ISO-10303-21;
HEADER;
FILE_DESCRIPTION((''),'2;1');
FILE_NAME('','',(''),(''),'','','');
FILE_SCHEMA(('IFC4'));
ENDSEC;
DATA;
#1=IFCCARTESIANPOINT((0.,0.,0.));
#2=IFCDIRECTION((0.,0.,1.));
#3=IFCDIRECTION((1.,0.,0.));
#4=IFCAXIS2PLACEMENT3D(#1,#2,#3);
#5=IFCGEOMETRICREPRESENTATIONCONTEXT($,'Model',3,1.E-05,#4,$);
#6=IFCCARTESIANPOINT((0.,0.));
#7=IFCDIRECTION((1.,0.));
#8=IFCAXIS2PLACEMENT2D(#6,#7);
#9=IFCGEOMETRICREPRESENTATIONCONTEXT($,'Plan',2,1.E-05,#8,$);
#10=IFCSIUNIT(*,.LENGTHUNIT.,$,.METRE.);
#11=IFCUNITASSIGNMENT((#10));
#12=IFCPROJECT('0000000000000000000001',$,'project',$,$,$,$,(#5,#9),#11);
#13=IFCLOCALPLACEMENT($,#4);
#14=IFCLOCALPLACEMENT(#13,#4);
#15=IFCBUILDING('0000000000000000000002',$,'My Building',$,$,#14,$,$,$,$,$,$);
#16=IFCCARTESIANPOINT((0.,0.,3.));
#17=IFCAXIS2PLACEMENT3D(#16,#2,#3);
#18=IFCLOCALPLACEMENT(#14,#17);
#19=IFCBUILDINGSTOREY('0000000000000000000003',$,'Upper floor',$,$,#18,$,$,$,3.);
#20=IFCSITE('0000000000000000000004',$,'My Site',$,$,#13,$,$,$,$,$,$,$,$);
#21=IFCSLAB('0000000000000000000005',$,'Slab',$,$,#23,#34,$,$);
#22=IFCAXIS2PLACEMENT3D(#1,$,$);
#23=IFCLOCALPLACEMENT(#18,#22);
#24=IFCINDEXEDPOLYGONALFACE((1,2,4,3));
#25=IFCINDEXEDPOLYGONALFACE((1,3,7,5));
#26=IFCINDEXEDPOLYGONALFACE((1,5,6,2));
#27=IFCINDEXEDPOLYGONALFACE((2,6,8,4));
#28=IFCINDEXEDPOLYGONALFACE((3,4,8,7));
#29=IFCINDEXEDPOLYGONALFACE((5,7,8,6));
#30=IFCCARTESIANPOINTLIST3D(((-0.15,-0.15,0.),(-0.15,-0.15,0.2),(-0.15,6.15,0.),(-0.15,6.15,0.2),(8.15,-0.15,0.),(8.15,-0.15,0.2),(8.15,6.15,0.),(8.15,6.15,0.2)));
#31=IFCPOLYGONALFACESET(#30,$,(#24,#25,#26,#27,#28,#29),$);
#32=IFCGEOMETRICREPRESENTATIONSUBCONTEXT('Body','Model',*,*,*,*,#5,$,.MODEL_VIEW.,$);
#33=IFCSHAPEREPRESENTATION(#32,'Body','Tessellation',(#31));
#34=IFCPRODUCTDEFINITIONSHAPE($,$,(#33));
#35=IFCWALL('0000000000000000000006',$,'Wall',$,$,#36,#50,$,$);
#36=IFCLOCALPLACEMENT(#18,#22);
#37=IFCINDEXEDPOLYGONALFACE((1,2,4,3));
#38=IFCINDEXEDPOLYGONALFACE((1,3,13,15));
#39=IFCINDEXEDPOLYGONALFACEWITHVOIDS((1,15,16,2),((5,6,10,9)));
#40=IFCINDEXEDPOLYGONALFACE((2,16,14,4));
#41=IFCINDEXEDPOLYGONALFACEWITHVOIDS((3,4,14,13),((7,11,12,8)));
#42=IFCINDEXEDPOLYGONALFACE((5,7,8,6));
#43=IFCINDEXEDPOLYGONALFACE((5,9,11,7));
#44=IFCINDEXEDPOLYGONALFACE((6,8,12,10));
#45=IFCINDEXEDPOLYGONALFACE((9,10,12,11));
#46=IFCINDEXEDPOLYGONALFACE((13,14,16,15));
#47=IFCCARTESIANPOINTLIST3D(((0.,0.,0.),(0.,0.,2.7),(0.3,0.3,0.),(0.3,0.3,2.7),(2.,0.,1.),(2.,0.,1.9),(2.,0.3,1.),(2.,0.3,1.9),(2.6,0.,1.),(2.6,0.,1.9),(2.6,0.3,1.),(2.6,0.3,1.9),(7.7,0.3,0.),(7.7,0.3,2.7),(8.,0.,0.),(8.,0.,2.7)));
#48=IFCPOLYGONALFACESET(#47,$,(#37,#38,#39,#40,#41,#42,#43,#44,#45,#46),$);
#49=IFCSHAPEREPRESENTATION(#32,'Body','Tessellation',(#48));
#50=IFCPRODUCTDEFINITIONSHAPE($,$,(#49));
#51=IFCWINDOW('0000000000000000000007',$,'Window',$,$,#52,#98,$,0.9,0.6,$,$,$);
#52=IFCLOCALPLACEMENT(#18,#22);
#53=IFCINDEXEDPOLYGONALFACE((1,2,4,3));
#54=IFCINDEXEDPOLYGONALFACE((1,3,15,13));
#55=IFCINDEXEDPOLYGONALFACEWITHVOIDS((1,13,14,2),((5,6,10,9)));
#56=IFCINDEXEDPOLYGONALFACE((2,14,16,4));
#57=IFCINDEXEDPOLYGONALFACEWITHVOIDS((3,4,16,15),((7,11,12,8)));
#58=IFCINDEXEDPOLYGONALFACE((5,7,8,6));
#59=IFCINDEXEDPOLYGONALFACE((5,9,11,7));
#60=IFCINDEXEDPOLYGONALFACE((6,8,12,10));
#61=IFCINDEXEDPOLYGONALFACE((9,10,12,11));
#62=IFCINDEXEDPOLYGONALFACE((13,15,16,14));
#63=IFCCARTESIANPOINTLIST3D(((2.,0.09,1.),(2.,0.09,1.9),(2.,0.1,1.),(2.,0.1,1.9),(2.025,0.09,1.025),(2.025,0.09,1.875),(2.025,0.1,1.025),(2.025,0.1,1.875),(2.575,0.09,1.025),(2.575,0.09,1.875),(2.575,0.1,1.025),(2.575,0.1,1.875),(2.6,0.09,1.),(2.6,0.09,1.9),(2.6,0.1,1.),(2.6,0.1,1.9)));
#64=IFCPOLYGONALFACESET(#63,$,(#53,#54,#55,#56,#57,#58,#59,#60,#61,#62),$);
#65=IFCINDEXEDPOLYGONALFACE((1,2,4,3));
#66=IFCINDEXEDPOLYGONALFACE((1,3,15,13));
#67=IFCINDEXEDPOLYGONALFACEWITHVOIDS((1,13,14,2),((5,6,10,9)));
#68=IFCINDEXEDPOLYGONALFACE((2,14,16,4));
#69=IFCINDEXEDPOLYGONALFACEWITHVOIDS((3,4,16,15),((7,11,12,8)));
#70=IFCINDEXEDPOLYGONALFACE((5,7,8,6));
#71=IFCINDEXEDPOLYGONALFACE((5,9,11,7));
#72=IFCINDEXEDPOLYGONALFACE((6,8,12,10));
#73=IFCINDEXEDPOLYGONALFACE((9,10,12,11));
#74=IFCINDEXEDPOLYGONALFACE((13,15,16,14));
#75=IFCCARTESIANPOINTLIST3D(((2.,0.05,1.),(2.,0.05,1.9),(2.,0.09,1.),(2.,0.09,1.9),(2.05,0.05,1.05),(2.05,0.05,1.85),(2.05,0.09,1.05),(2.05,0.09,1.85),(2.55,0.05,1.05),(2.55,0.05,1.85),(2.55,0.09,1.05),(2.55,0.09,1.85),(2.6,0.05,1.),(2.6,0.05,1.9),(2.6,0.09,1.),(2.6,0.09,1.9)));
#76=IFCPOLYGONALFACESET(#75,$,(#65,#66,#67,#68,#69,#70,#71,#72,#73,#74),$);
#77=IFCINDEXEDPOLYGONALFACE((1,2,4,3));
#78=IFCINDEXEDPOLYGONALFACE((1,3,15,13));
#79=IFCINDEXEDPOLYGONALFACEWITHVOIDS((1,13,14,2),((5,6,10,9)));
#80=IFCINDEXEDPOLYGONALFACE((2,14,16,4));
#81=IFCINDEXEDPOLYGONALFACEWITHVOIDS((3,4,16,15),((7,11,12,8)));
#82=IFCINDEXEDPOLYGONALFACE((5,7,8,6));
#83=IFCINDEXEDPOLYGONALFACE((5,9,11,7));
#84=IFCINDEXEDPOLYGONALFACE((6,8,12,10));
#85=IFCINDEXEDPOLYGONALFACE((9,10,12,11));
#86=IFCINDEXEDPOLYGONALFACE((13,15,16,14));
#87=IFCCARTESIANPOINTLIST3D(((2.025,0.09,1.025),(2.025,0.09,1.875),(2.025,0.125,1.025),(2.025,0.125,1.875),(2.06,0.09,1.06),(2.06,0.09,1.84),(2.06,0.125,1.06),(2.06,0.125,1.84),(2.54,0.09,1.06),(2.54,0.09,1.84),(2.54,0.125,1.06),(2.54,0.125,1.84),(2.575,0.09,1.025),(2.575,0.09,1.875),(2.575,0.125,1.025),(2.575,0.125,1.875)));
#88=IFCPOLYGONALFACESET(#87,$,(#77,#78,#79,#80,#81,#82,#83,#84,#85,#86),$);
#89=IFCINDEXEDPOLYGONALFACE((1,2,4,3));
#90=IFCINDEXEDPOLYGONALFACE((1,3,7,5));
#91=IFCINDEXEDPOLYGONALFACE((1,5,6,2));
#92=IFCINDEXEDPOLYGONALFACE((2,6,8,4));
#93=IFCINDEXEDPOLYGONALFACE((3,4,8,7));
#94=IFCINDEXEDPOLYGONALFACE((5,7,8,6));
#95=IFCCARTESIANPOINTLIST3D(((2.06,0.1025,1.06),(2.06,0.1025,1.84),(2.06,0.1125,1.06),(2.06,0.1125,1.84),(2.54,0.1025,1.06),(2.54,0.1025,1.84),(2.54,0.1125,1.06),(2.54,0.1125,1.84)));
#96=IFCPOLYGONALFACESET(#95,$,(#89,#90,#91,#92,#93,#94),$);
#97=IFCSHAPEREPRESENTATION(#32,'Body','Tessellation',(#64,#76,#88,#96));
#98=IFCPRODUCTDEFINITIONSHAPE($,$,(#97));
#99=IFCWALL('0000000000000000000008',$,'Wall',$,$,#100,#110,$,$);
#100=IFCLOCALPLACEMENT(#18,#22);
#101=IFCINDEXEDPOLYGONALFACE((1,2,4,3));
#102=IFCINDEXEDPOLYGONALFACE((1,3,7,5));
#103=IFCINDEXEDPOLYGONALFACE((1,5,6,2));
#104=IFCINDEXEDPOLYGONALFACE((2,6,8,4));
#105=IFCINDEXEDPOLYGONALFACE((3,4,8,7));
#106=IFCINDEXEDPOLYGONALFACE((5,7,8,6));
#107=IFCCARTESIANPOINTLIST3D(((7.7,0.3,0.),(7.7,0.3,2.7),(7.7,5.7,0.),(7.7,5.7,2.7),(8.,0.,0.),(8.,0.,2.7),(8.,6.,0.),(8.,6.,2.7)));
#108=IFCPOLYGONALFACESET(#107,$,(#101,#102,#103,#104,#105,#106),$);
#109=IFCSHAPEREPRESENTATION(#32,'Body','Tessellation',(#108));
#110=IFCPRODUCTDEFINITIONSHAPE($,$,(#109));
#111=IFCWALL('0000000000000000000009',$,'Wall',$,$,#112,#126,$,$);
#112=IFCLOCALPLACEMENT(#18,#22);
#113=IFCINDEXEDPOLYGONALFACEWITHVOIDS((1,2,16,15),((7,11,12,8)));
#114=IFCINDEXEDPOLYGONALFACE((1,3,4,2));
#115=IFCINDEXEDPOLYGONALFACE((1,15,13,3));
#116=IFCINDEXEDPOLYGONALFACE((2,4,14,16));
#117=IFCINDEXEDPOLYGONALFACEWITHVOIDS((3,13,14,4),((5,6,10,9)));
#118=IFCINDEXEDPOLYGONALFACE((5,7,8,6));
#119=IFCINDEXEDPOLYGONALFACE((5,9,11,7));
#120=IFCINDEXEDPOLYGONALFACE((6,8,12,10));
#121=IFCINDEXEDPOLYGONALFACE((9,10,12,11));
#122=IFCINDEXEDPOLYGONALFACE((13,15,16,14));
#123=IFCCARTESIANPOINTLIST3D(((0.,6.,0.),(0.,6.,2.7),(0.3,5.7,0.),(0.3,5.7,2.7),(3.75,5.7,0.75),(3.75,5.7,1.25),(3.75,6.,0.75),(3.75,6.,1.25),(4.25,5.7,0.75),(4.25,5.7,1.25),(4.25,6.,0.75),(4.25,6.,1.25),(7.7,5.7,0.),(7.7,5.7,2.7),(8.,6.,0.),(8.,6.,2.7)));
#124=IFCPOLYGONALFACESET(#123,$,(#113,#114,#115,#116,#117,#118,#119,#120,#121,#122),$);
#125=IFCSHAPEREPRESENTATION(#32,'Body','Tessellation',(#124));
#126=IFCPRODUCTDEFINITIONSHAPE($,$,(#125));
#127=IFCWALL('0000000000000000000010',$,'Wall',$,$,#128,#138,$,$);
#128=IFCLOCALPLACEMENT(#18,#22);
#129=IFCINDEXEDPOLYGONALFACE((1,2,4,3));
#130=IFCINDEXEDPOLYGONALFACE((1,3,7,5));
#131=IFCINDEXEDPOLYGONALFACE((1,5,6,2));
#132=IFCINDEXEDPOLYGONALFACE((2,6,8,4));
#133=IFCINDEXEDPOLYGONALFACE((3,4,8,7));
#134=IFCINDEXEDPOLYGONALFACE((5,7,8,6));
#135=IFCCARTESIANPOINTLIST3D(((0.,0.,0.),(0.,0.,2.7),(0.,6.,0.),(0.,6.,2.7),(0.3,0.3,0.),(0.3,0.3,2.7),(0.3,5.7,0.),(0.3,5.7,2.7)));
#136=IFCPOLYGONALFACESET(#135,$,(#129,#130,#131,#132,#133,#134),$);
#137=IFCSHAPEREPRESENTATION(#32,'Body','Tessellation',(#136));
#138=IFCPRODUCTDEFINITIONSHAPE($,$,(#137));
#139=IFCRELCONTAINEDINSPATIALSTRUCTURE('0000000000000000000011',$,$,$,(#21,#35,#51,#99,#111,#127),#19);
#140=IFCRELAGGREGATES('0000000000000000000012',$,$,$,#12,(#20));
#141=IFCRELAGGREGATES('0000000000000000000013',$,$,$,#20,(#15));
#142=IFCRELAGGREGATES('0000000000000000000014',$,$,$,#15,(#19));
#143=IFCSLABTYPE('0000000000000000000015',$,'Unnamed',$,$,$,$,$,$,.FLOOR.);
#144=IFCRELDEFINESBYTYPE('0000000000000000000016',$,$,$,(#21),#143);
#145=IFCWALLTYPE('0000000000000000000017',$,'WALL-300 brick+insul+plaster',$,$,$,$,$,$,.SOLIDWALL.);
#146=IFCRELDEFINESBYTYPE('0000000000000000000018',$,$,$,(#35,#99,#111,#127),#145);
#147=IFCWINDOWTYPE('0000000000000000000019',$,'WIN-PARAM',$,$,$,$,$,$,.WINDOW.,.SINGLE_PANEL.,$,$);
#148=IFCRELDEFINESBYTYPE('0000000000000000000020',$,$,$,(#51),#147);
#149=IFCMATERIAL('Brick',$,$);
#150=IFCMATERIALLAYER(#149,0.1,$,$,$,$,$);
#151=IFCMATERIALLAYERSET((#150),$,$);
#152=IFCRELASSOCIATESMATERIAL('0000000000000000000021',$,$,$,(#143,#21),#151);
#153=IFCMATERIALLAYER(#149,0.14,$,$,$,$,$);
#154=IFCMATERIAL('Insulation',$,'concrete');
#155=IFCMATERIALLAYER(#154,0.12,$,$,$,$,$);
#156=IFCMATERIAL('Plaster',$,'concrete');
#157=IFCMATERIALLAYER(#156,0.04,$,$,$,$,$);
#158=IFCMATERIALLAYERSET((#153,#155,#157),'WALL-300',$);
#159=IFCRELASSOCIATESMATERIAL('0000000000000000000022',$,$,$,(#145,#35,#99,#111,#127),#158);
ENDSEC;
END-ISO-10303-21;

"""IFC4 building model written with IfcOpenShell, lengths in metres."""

from ifc_helpers import new_model, entity, si_unit, frame, origin_with_axes, origin_2d_with_axis, place, context, subcontext, project, spatial, line, indexed_curve, outline, extrude, shape, source, transform, mapped, material, layer, layer_set, layer_usage, type_object, type_shapes, element, fill, save


model = new_model("IFC4")

# Units and contexts
model_context = context("Model", 3, precision=1e-05, world=origin_with_axes())
plan_context = context("Plan", 2, precision=1e-05, world=origin_2d_with_axis())
body_context_1 = subcontext(model_context, "Body", "Model", "MODEL_VIEW")
body_context_2 = subcontext(plan_context, "Body", "Plan", "PLAN_VIEW")
ifc_project = project(units=[si_unit("LENGTHUNIT", "METRE")], contexts=[model_context, plan_context])

# Site, building, storey
site_placement = place(None, origin_with_axes())
site = spatial("IfcSite", under=ifc_project, at=site_placement, Name="My Site")
building_placement = place(site_placement, origin_with_axes())
building = spatial("IfcBuilding", under=site, at=building_placement, Name="My Building")
storey_placement = place(building_placement, frame((0.0, 0.0, 3.0), z_axis=(0.0, 0.0, 1.0), x_axis=(1.0, 0.0, 0.0)))
storey = spatial("IfcBuildingStorey", under=building, at=storey_placement, Name="Upper floor", Elevation=3.0)

# Slab
ifc_material_1 = material(Name="Brick")
ifc_layer_1 = layer(ifc_material_1, 0.1)
ifc_layer_set_1 = layer_set([ifc_layer_1])
ifc_layer_usage_1 = layer_usage(ifc_layer_set_1, "AXIS3", "POSITIVE", 0.0)
slab_type = type_object("IfcSlabType", Name="Unnamed", PredefinedType="FLOOR", material=ifc_layer_set_1)
slab_placement = place(storey_placement, origin_with_axes())
element("IfcSlab", 1, at=slab_placement, inside=storey, type_object=slab_type, material=ifc_layer_usage_1, Name="Slab", context=body_context_1, shape_type="SweptSolid", body=[
    extrude(outline(indexed_curve([(-0.15, -0.15), (8.15, -0.15), (8.15, 6.15), (-0.15, 6.15), (-0.15, -0.15)])), None, (0.0, 0.0, 1.0), 0.2),
])

# Wall, opening, window
ifc_layer_2 = layer(ifc_material_1, 0.14)
ifc_material_2 = material(Name="Insulation", Category="concrete")
ifc_layer_3 = layer(ifc_material_2, 0.12)
ifc_material_3 = material(Name="Plaster", Category="concrete")
ifc_layer_4 = layer(ifc_material_3, 0.04)
ifc_layer_set_2 = layer_set([ifc_layer_2, ifc_layer_3, ifc_layer_4], Name="WALL-300")
ifc_layer_usage_2 = layer_usage(ifc_layer_set_2, "AXIS2", "POSITIVE", 0.0)
wall_type = type_object("IfcWallType", Name="WALL-300 brick+insul+plaster", PredefinedType="SOLIDWALL", material=ifc_layer_set_2)
wall_1_placement = place(storey_placement, frame((0.0, 0.0, 0.0), z_axis=(0.0, 0.0, 1.0), x_axis=(1.0, 0.0, 0.0)))
wall_1 = element("IfcWall", 2, at=wall_1_placement, inside=storey, type_object=wall_type, material=ifc_layer_usage_2, Name="Wall", context=body_context_1, shape_type="SweptSolid", body=[
    extrude(outline(indexed_curve([(0.0, 0.0), (0.3, 0.3), (7.7, 0.3), (8.0, 0.0)], segments=[line(1, 2, 3, 4, 1)])), origin_with_axes(), (0.0, 0.0, 1.0), 2.7),
])
shared_shape_1 = source(origin_with_axes(), body_context_1, "Body", "SweptSolid", [
    extrude(outline(indexed_curve([(0.0, 0.0), (0.6, 0.0), (0.6, 0.9), (0.0, 0.9)], segments=[line(1, 2, 3, 4, 1)])), frame((0.0, -0.6, 0.0), z_axis=(0.0, -1.0, 0.0), x_axis=(1.0, 0.0, 0.0)), (0.0, 0.0, -1.0), 1.2),
])
opening_1_placement = place(wall_1_placement, frame((2.0, 0.0, 1.0), z_axis=(0.0, 0.0, 1.0), x_axis=(1.0, 0.0, 0.0)))
opening_1 = element("IfcOpeningElement", 3, at=opening_1_placement, cuts=wall_1, PredefinedType="OPENING", context=body_context_1, shape_type="MappedRepresentation", body=[
    mapped(shared_shape_1, transform((0.0, 0.0, 0.0), x_axis=(1.0, 0.0, 0.0), y_axis=(0.0, 1.0, 0.0), z_axis=(0.0, 0.0, 1.0), scale=1.0)),
])
window_type = type_object("IfcWindowType", Name="WIN-PARAM", PartitioningType="SINGLE_PANEL", PredefinedType="WINDOW")
shared_shape_2 = source(origin_with_axes(), body_context_1, "Body", "SweptSolid", [
    extrude(outline(indexed_curve([(0.0, 0.0), (0.6, 0.0), (0.6, 0.9), (0.0, 0.9)], segments=[line(1, 2, 3, 4, 1)]), holes=[indexed_curve([(0.025, 0.025), (0.575, 0.025), (0.575, 0.875), (0.025, 0.875)], segments=[line(1, 2, 3, 4, 1)])]), frame((0.0, 0.09, 0.0), z_axis=(0.0, -1.0, 0.0), x_axis=(1.0, 0.0, 0.0)), (0.0, 0.0, -1.0), 0.01),
    extrude(outline(indexed_curve([(0.0, 0.0), (0.6, 0.0), (0.6, 0.9), (0.0, 0.9)], segments=[line(1, 2, 3, 4, 1)]), holes=[indexed_curve([(0.05, 0.05), (0.55, 0.05), (0.55, 0.85), (0.05, 0.85)], segments=[line(1, 2, 3, 4, 1)])]), frame((0.0, 0.05, 0.0), z_axis=(0.0, -1.0, 0.0), x_axis=(1.0, 0.0, 0.0)), (0.0, 0.0, -1.0), 0.04),
    extrude(outline(indexed_curve([(0.0, 0.0), (0.55, 0.0), (0.55, 0.85), (0.0, 0.85)], segments=[line(1, 2, 3, 4, 1)]), holes=[indexed_curve([(0.035, 0.035), (0.515, 0.035), (0.515, 0.815), (0.035, 0.815)], segments=[line(1, 2, 3, 4, 1)])]), frame((0.025, 0.09, 0.025), z_axis=(0.0, -1.0, 0.0), x_axis=(1.0, 0.0, 0.0)), (0.0, 0.0, -1.0), 0.035),
    extrude(outline(indexed_curve([(0.035, 0.035), (0.515, 0.035), (0.515, 0.815), (0.035, 0.815)], segments=[line(1, 2, 3, 4, 1)])), frame((0.025, 0.1025, 0.025), z_axis=(0.0, -1.0, 0.0), x_axis=(1.0, 0.0, 0.0)), (0.0, 0.0, -1.0), 0.01),
])
shared_shape_3 = source(origin_with_axes(), body_context_2, "Body", "Curve2D", [
    entity("IfcIndexedPolyCurve", entity("IfcCartesianPointList2D", [[0.05, 0.05], [0.55, 0.05]])),
    entity("IfcIndexedPolyCurve", entity("IfcCartesianPointList2D", [[0.0, 0.1], [0.025, 0.1], [0.025, 0.09], [0.05, 0.09], [0.05, 0.05], [0.0, 0.05]]), [entity("IfcLineIndex", [1, 2, 3, 4, 5, 6, 1])]),
    entity("IfcIndexedPolyCurve", entity("IfcCartesianPointList2D", [[0.6, 0.1], [0.575, 0.1], [0.575, 0.09], [0.55, 0.09], [0.55, 0.05], [0.6, 0.05]]), [entity("IfcLineIndex", [1, 2, 3, 4, 5, 6, 1])]),
    entity("IfcIndexedPolyCurve", entity("IfcCartesianPointList2D", [[0.025, 0.09], [0.06, 0.09], [0.06, 0.125], [0.025, 0.125]]), [entity("IfcLineIndex", [1, 2, 3, 4, 1])]),
    entity("IfcIndexedPolyCurve", entity("IfcCartesianPointList2D", [[0.575, 0.09], [0.54, 0.09], [0.54, 0.125], [0.575, 0.125]]), [entity("IfcLineIndex", [1, 2, 3, 4, 1])]),
    entity("IfcIndexedPolyCurve", entity("IfcCartesianPointList2D", [[0.06, 0.09], [0.54, 0.09]])),
    entity("IfcIndexedPolyCurve", entity("IfcCartesianPointList2D", [[0.06, 0.125], [0.54, 0.125]])),
    entity("IfcIndexedPolyCurve", entity("IfcCartesianPointList2D", [[0.06, 0.1075], [0.54, 0.1075]])),
])
type_shapes(window_type, [shared_shape_2, shared_shape_3])
window_placement = place(opening_1_placement, origin_with_axes())
window = element("IfcWindow", 4, at=window_placement, inside=storey, type_object=window_type, Name="Window", OverallHeight=0.9, OverallWidth=0.6, shapes=[
    shape(body_context_1, "Body", "MappedRepresentation", [mapped(shared_shape_2, transform((0.0, 0.0, 0.0), x_axis=(1.0, 0.0, 0.0), y_axis=(0.0, 1.0, 0.0), z_axis=(0.0, 0.0, 1.0), scale=1.0))]),
    shape(body_context_2, "Body", "MappedRepresentation", [mapped(shared_shape_3, transform((0.0, 0.0, 0.0), x_axis=(1.0, 0.0, 0.0), y_axis=(0.0, 1.0, 0.0), z_axis=(0.0, 0.0, 1.0), scale=1.0))]),
])
fill(opening_1, window)

# Wall
ifc_layer_usage_3 = layer_usage(ifc_layer_set_2, "AXIS2", "POSITIVE", 0.0)
wall_2_placement = place(storey_placement, frame((8.0, 0.0, 0.0), z_axis=(0.0, 0.0, 1.0), x_axis=(0.0, 1.0, 0.0)))
element("IfcWall", 5, at=wall_2_placement, inside=storey, type_object=wall_type, material=ifc_layer_usage_3, Name="Wall", context=body_context_1, shape_type="SweptSolid", body=[
    extrude(outline(indexed_curve([(0.0, 0.0), (0.3, 0.3), (5.7, 0.3), (6.0, 0.0)], segments=[line(1, 2, 3, 4, 1)])), origin_with_axes(), (0.0, 0.0, 1.0), 2.7),
])

# Wall, opening
ifc_layer_usage_4 = layer_usage(ifc_layer_set_2, "AXIS2", "POSITIVE", 0.0)
wall_3_placement = place(storey_placement, frame((8.0, 6.0, 0.0), z_axis=(0.0, 0.0, 1.0), x_axis=(-1.0, 0.0, 0.0)))
wall_3 = element("IfcWall", 6, at=wall_3_placement, inside=storey, type_object=wall_type, material=ifc_layer_usage_4, Name="Wall", context=body_context_1, shape_type="SweptSolid", body=[
    extrude(outline(indexed_curve([(0.0, 0.0), (0.3, 0.3), (7.7, 0.3), (8.0, 0.0)], segments=[line(1, 2, 3, 4, 1)])), origin_with_axes(), (0.0, 0.0, 1.0), 2.7),
])
shared_shape_4 = source(origin_with_axes(), body_context_1, "Body", "SweptSolid", [
    extrude(outline(indexed_curve([(0.0, 0.0), (0.5, 0.0), (0.5, 0.5), (0.0, 0.5)], segments=[line(1, 2, 3, 4, 1)])), frame((-0.25, -0.6, -0.25), z_axis=(0.0, -1.0, 0.0), x_axis=(1.0, 0.0, 0.0)), (0.0, 0.0, -1.0), 1.2),
])
opening_2_placement = place(wall_3_placement, frame((4.0, 0.0, 1.0), z_axis=(0.0, 0.0, 1.0), x_axis=(1.0, 0.0, 0.0)))
element("IfcOpeningElement", 7, at=opening_2_placement, cuts=wall_3, PredefinedType="OPENING", context=body_context_1, shape_type="MappedRepresentation", body=[
    mapped(shared_shape_4, transform((0.0, 0.0, 0.0), x_axis=(1.0, 0.0, 0.0), y_axis=(0.0, 1.0, 0.0), z_axis=(0.0, 0.0, 1.0), scale=1.0)),
])

# Wall
ifc_layer_usage_5 = layer_usage(ifc_layer_set_2, "AXIS2", "POSITIVE", 0.0)
wall_4_placement = place(storey_placement, frame((0.0, 6.0, 0.0), z_axis=(0.0, 0.0, 1.0), x_axis=(0.0, -1.0, 0.0)))
element("IfcWall", 8, at=wall_4_placement, inside=storey, type_object=wall_type, material=ifc_layer_usage_5, Name="Wall", context=body_context_1, shape_type="SweptSolid", body=[
    extrude(outline(indexed_curve([(0.0, 0.0), (0.3, 0.3), (5.7, 0.3), (6.0, 0.0)], segments=[line(1, 2, 3, 4, 1)])), origin_with_axes(), (0.0, 0.0, 1.0), 2.7),
])

save(model, "model.ifc")
